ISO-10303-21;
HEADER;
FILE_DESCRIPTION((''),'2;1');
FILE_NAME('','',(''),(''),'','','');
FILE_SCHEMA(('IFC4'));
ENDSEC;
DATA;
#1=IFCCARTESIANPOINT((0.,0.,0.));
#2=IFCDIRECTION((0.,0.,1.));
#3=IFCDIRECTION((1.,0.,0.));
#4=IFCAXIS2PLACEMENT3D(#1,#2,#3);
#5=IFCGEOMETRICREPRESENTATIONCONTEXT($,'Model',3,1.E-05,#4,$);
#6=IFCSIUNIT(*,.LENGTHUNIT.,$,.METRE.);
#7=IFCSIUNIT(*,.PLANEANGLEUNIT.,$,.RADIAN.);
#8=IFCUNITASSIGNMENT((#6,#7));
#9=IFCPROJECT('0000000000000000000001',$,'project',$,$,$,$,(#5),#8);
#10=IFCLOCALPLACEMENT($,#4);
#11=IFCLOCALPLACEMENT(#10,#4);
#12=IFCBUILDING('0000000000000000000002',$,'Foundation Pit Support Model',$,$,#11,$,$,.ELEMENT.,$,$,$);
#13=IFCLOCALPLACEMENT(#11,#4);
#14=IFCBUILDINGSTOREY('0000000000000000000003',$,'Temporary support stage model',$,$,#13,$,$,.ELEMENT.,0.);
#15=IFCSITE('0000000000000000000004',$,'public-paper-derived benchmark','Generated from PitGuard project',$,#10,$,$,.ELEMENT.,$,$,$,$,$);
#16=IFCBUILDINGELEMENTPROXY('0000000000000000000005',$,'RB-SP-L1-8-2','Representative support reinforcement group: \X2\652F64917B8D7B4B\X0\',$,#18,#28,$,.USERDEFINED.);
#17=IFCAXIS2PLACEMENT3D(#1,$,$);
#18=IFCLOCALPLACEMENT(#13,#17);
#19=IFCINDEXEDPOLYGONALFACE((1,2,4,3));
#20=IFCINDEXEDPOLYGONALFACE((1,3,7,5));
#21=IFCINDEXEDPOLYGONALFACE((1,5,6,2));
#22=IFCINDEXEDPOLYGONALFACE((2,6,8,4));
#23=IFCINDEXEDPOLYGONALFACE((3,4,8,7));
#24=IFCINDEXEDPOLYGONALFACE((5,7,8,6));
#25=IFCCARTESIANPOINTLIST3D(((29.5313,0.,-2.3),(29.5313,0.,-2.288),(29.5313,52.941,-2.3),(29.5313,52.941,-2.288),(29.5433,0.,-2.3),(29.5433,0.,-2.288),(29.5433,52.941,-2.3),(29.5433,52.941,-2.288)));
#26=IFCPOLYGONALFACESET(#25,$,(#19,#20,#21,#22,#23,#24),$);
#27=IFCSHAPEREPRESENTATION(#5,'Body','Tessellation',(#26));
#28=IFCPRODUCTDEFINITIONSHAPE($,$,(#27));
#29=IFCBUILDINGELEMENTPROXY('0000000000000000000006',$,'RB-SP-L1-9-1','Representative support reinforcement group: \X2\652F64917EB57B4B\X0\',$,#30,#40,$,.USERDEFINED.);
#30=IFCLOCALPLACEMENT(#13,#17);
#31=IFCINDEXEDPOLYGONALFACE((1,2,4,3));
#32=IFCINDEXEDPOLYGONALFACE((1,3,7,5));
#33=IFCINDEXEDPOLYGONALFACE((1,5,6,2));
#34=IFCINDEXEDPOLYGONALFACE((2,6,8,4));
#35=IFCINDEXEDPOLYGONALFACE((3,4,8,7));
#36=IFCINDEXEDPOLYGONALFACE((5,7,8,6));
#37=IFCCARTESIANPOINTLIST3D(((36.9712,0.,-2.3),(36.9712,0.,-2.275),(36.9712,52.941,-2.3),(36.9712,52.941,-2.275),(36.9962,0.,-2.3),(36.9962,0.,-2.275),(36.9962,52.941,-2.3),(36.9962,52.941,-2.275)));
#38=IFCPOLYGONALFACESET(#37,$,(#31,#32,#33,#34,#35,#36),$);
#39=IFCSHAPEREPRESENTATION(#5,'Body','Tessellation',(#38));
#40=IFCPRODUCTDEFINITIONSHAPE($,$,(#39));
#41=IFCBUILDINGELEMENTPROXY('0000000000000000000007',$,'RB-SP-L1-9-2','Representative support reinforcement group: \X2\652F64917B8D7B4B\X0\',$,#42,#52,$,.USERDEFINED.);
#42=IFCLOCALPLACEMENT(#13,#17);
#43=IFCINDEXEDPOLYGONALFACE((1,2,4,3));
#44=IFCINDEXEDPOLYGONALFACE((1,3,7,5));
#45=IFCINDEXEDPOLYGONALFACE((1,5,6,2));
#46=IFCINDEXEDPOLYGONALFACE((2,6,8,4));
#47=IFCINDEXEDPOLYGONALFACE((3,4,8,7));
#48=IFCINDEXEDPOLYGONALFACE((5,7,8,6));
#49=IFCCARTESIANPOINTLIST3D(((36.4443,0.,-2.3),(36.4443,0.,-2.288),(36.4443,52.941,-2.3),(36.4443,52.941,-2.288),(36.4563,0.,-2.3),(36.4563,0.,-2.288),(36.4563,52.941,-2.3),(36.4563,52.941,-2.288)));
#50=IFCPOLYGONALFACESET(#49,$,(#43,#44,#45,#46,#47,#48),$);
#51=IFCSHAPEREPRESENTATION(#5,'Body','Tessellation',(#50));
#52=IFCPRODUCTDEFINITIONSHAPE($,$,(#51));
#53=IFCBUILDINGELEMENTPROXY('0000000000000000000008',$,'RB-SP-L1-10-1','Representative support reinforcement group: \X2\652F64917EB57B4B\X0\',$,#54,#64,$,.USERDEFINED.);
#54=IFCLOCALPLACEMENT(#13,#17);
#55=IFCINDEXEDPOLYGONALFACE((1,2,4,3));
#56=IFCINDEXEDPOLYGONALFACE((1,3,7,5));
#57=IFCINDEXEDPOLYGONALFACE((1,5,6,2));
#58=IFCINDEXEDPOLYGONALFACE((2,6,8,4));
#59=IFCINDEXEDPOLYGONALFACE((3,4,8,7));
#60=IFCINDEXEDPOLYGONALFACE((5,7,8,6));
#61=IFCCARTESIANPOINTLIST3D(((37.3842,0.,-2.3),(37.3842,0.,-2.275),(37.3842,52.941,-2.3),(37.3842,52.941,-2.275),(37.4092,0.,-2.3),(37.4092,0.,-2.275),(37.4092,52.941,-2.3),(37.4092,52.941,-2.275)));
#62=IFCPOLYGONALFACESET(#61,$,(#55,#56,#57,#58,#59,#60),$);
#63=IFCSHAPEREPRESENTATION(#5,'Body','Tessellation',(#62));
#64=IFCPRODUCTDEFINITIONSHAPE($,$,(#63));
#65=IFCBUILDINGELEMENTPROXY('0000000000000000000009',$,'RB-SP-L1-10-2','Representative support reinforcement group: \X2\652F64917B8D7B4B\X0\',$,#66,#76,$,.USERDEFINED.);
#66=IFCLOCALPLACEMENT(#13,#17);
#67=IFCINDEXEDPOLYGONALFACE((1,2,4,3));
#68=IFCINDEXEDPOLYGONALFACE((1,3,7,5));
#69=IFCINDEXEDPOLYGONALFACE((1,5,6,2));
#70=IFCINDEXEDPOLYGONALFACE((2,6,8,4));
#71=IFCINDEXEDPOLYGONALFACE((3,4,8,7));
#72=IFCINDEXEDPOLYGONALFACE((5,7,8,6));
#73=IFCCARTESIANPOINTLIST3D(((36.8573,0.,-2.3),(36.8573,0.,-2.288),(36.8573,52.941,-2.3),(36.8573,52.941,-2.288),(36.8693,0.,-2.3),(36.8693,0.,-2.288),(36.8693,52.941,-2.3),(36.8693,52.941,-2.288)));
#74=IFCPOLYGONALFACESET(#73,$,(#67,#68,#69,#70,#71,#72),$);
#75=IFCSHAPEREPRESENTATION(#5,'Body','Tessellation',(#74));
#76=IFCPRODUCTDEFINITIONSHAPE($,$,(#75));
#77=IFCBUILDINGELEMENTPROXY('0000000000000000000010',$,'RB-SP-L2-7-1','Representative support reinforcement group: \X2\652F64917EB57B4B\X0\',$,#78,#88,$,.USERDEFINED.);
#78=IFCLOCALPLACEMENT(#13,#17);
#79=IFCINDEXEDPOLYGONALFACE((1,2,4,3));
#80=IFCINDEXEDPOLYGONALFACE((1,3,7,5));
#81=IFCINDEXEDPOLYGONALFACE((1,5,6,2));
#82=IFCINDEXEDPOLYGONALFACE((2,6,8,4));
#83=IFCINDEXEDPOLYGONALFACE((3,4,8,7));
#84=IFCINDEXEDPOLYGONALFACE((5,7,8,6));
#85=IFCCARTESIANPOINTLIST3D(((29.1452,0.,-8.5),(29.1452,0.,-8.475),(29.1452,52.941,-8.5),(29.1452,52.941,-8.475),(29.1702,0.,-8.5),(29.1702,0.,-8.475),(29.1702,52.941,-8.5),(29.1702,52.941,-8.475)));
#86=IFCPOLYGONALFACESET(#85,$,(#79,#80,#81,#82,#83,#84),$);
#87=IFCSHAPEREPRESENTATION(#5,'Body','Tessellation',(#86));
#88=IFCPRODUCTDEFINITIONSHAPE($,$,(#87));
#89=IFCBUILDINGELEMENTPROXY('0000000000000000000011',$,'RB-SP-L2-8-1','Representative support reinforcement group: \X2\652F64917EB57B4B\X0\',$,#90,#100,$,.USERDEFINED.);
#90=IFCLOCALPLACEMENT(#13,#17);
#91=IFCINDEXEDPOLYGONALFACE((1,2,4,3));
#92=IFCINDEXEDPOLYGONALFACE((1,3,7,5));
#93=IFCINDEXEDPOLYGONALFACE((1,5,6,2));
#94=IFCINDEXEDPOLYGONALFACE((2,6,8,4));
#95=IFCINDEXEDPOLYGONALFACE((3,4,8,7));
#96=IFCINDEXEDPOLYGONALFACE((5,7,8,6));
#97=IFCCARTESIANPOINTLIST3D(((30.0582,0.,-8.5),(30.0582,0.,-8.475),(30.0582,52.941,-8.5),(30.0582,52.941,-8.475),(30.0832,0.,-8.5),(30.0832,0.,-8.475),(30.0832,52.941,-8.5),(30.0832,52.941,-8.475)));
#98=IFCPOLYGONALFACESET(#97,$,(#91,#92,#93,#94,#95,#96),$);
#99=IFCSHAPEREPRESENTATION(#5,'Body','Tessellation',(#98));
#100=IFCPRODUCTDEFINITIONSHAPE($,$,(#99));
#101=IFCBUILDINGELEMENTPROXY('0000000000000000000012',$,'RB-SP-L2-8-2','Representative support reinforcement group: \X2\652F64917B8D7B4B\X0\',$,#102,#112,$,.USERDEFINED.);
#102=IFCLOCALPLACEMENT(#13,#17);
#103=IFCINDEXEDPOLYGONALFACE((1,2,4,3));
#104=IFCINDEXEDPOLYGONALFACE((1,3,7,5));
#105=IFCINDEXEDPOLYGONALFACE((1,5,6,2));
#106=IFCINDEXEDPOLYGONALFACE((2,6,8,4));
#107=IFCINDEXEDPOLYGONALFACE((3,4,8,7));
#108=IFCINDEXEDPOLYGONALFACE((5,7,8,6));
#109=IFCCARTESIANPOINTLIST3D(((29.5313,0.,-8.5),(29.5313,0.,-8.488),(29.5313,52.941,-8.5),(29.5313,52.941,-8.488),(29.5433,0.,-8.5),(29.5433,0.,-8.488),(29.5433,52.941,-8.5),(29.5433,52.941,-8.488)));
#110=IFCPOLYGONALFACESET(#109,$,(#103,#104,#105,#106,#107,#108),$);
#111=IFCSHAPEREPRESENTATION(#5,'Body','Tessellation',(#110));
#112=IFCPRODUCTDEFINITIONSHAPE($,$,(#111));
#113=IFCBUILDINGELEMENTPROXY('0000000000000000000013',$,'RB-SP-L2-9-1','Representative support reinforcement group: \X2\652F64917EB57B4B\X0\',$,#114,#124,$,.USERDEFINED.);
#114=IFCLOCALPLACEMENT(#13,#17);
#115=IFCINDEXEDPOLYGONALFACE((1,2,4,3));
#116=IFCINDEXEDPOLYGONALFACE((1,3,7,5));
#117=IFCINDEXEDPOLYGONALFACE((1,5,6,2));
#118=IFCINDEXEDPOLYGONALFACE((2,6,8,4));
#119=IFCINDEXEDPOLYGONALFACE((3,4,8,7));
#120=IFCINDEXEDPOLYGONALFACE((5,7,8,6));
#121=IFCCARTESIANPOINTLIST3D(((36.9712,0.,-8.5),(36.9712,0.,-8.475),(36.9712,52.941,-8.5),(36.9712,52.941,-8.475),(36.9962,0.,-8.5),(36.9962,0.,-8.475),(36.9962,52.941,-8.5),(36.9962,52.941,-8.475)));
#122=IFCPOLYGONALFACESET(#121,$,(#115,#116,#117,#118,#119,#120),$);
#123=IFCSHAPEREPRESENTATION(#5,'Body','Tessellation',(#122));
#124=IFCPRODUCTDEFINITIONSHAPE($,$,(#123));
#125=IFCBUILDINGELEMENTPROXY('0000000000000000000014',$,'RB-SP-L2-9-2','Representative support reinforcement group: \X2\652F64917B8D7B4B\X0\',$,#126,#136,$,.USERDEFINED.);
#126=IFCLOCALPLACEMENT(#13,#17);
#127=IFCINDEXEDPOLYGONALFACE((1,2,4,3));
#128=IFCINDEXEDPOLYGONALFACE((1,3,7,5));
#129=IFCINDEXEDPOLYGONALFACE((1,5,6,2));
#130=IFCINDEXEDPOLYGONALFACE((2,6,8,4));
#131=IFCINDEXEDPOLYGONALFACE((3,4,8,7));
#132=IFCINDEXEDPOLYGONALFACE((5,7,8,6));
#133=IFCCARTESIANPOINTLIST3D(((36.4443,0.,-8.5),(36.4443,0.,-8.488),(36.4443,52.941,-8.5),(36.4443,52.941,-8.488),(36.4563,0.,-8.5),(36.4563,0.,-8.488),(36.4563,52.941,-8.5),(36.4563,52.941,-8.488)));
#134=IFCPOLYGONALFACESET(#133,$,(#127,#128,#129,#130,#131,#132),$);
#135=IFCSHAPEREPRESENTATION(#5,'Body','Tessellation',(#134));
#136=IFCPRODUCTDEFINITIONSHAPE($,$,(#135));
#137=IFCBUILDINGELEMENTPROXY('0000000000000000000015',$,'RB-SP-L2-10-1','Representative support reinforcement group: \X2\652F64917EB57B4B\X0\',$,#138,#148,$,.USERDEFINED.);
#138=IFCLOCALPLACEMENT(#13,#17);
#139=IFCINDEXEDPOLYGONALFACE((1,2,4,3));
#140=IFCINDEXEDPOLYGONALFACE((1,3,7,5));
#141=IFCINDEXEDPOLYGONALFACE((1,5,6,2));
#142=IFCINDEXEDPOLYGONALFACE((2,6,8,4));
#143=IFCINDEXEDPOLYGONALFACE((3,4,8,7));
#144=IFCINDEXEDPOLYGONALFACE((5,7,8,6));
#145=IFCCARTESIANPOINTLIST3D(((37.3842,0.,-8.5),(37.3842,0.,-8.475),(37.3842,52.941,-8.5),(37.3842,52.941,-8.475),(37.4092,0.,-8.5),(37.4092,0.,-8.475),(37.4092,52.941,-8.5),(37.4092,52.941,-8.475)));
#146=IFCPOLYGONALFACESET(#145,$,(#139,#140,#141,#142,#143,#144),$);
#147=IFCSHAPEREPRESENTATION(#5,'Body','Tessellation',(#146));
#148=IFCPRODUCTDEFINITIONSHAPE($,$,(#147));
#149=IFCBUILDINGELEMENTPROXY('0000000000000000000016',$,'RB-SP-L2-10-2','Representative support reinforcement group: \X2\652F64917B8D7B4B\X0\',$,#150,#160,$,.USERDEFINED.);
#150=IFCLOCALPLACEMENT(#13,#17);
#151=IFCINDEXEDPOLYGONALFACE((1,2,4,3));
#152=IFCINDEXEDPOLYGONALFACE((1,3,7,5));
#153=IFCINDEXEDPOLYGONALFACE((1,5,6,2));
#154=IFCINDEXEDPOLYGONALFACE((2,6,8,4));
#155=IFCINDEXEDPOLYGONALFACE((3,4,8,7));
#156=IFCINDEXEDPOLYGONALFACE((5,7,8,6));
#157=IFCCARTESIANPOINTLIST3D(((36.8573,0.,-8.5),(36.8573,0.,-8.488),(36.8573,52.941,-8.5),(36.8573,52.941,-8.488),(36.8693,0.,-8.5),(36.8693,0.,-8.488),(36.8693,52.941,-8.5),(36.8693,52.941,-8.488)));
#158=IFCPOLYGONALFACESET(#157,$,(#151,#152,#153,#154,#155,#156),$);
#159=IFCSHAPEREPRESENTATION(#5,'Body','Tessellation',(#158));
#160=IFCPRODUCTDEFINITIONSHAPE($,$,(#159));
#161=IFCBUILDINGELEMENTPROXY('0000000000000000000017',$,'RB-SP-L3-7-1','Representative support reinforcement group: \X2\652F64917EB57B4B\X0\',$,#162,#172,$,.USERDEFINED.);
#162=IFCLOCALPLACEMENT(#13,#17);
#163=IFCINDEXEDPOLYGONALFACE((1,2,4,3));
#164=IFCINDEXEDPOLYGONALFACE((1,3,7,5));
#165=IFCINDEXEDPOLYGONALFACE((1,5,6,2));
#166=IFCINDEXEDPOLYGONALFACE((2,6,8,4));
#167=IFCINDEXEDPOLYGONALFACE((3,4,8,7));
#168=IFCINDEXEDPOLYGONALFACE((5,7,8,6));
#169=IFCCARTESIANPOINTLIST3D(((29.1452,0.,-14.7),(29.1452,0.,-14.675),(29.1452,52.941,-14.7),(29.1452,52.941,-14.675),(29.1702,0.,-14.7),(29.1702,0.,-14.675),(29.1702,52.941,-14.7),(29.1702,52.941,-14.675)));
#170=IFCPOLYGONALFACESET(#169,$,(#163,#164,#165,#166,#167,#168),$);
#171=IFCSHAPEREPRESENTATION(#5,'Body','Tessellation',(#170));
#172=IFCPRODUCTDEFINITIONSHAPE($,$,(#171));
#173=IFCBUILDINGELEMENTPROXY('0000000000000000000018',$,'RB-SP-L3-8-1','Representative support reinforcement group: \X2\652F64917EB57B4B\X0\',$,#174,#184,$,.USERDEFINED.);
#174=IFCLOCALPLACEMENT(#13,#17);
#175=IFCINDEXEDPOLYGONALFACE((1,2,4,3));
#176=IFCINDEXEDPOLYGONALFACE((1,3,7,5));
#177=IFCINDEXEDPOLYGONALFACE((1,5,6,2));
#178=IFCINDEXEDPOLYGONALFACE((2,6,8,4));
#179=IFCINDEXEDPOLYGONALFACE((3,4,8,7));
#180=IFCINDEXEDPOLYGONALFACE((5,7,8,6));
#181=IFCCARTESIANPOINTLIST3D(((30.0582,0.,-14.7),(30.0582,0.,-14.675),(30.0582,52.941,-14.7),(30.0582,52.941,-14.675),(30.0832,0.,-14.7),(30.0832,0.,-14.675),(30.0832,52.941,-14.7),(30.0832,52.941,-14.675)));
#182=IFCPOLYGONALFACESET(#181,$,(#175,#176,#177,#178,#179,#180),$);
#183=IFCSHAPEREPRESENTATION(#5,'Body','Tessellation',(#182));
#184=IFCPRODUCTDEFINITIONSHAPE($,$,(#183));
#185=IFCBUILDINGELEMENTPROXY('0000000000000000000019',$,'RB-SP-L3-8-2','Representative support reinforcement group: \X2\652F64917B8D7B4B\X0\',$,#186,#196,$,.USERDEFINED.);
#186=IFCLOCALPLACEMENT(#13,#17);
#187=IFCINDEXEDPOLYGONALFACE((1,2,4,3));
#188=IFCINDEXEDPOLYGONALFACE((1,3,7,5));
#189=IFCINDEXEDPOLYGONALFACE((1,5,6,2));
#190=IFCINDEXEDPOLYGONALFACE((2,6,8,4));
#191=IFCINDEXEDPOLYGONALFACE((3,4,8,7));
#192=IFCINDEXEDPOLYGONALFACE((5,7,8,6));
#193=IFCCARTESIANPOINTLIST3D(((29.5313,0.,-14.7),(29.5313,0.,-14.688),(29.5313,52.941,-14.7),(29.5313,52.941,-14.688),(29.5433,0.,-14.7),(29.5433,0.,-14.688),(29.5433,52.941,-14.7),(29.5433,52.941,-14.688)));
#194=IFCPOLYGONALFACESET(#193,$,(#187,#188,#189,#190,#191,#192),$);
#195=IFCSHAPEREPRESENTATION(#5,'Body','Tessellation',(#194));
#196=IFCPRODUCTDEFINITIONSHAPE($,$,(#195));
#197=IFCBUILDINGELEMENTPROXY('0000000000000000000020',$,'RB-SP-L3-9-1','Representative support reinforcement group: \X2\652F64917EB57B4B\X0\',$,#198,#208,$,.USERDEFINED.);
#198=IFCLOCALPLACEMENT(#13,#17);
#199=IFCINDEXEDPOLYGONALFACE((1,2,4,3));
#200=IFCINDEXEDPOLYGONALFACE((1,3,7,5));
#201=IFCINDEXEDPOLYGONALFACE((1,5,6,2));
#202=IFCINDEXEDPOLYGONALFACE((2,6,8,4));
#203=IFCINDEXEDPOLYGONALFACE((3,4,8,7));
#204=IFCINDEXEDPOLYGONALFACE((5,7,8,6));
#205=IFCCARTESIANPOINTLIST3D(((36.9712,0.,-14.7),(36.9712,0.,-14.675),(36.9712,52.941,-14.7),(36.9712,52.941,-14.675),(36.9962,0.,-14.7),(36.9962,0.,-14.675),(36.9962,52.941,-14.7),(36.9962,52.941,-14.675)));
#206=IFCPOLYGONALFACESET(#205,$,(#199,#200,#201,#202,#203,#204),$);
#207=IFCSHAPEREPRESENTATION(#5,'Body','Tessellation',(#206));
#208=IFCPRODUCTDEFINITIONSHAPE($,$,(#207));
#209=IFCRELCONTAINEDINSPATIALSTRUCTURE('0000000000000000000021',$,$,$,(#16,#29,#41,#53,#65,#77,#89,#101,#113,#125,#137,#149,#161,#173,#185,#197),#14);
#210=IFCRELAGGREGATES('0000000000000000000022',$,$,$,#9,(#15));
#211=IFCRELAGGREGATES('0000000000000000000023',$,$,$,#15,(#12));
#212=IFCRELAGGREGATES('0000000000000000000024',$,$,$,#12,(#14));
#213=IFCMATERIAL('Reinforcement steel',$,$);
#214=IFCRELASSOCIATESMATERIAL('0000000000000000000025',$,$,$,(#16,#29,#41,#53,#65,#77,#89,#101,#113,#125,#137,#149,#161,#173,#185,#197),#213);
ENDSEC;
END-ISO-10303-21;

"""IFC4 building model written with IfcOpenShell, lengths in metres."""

from ifc_helpers import new_model, si_unit, frame, origin_with_axes, origin_2d, place, context, project, spatial, rectangle, extrude, material, element, save


model = new_model("IFC4")

# Units and contexts
model_context = context("Model", 3, precision=1e-05, world=origin_with_axes())
ifc_project = project(units=[si_unit("LENGTHUNIT", "METRE"), si_unit("PLANEANGLEUNIT", "RADIAN")], contexts=[model_context])

# Site, building, storey
site_placement = place(None, origin_with_axes())
site = spatial("IfcSite", under=ifc_project, at=site_placement, Name="public-paper-derived benchmark", Description="Generated from PitGuard project", CompositionType="ELEMENT")
building_placement = place(site_placement, origin_with_axes())
building = spatial("IfcBuilding", under=site, at=building_placement, Name="Foundation Pit Support Model", CompositionType="ELEMENT")
storey_placement = place(building_placement, origin_with_axes())
storey = spatial("IfcBuildingStorey", under=building, at=storey_placement, Name="Temporary support stage model", CompositionType="ELEMENT", Elevation=0.0)

# Building element proxies
ifc_material_1 = material(Name="Reinforcement steel")
proxy_1_placement = place(storey_placement, frame((29.5373, 26.4705, -2.3), z_axis=(0.0, 0.0, 1.0), x_axis=(0.0, 1.0, 0.0)))
element("IfcBuildingElementProxy", 1, at=proxy_1_placement, inside=storey, material=ifc_material_1, Name="RB-SP-L1-8-2", Description="Representative support reinforcement group: 支撑箍筋", PredefinedType="USERDEFINED", context=model_context, shape_type="SweptSolid", body=[
    extrude(rectangle(XDim=52.941, YDim=0.012, at=origin_2d()), origin_with_axes(), (0.0, 0.0, 1.0), 0.012),
])
proxy_2_placement = place(storey_placement, frame((36.9837, 26.4705, -2.3), z_axis=(0.0, 0.0, 1.0), x_axis=(0.0, 1.0, 0.0)))
element("IfcBuildingElementProxy", 2, at=proxy_2_placement, inside=storey, material=ifc_material_1, Name="RB-SP-L1-9-1", Description="Representative support reinforcement group: 支撑纵筋", PredefinedType="USERDEFINED", context=model_context, shape_type="SweptSolid", body=[
    extrude(rectangle(XDim=52.941, YDim=0.025, at=origin_2d()), origin_with_axes(), (0.0, 0.0, 1.0), 0.025),
])
proxy_3_placement = place(storey_placement, frame((36.4503, 26.4705, -2.3), z_axis=(0.0, 0.0, 1.0), x_axis=(0.0, 1.0, 0.0)))
element("IfcBuildingElementProxy", 3, at=proxy_3_placement, inside=storey, material=ifc_material_1, Name="RB-SP-L1-9-2", Description="Representative support reinforcement group: 支撑箍筋", PredefinedType="USERDEFINED", context=model_context, shape_type="SweptSolid", body=[
    extrude(rectangle(XDim=52.941, YDim=0.012, at=origin_2d()), origin_with_axes(), (0.0, 0.0, 1.0), 0.012),
])
proxy_4_placement = place(storey_placement, frame((37.3967, 26.4705, -2.3), z_axis=(0.0, 0.0, 1.0), x_axis=(0.0, 1.0, 0.0)))
element("IfcBuildingElementProxy", 4, at=proxy_4_placement, inside=storey, material=ifc_material_1, Name="RB-SP-L1-10-1", Description="Representative support reinforcement group: 支撑纵筋", PredefinedType="USERDEFINED", context=model_context, shape_type="SweptSolid", body=[
    extrude(rectangle(XDim=52.941, YDim=0.025, at=origin_2d()), origin_with_axes(), (0.0, 0.0, 1.0), 0.025),
])
proxy_5_placement = place(storey_placement, frame((36.8633, 26.4705, -2.3), z_axis=(0.0, 0.0, 1.0), x_axis=(0.0, 1.0, 0.0)))
element("IfcBuildingElementProxy", 5, at=proxy_5_placement, inside=storey, material=ifc_material_1, Name="RB-SP-L1-10-2", Description="Representative support reinforcement group: 支撑箍筋", PredefinedType="USERDEFINED", context=model_context, shape_type="SweptSolid", body=[
    extrude(rectangle(XDim=52.941, YDim=0.012, at=origin_2d()), origin_with_axes(), (0.0, 0.0, 1.0), 0.012),
])
for number, where, z_axis, x_axis, name in (
    (6, (29.1577, 26.4705, -8.5), (0.0, 0.0, 1.0), (0.0, 1.0, 0.0), "RB-SP-L2-7-1"),
    (7, (30.0707, 26.4705, -8.5), (0.0, 0.0, 1.0), (0.0, 1.0, 0.0), "RB-SP-L2-8-1"),
):
    element("IfcBuildingElementProxy", number, at=place(storey_placement, frame(where, z_axis=z_axis, x_axis=x_axis)), inside=storey, material=ifc_material_1, Name=name, Description="Representative support reinforcement group: 支撑纵筋", PredefinedType="USERDEFINED", context=model_context, shape_type="SweptSolid", body=[
        extrude(rectangle(XDim=52.941, YDim=0.025, at=origin_2d()), origin_with_axes(), (0.0, 0.0, 1.0), 0.025),
    ])
proxy_6_placement = place(storey_placement, frame((29.5373, 26.4705, -8.5), z_axis=(0.0, 0.0, 1.0), x_axis=(0.0, 1.0, 0.0)))
element("IfcBuildingElementProxy", 8, at=proxy_6_placement, inside=storey, material=ifc_material_1, Name="RB-SP-L2-8-2", Description="Representative support reinforcement group: 支撑箍筋", PredefinedType="USERDEFINED", context=model_context, shape_type="SweptSolid", body=[
    extrude(rectangle(XDim=52.941, YDim=0.012, at=origin_2d()), origin_with_axes(), (0.0, 0.0, 1.0), 0.012),
])
proxy_7_placement = place(storey_placement, frame((36.9837, 26.4705, -8.5), z_axis=(0.0, 0.0, 1.0), x_axis=(0.0, 1.0, 0.0)))
element("IfcBuildingElementProxy", 9, at=proxy_7_placement, inside=storey, material=ifc_material_1, Name="RB-SP-L2-9-1", Description="Representative support reinforcement group: 支撑纵筋", PredefinedType="USERDEFINED", context=model_context, shape_type="SweptSolid", body=[
    extrude(rectangle(XDim=52.941, YDim=0.025, at=origin_2d()), origin_with_axes(), (0.0, 0.0, 1.0), 0.025),
])
proxy_8_placement = place(storey_placement, frame((36.4503, 26.4705, -8.5), z_axis=(0.0, 0.0, 1.0), x_axis=(0.0, 1.0, 0.0)))
element("IfcBuildingElementProxy", 10, at=proxy_8_placement, inside=storey, material=ifc_material_1, Name="RB-SP-L2-9-2", Description="Representative support reinforcement group: 支撑箍筋", PredefinedType="USERDEFINED", context=model_context, shape_type="SweptSolid", body=[
    extrude(rectangle(XDim=52.941, YDim=0.012, at=origin_2d()), origin_with_axes(), (0.0, 0.0, 1.0), 0.012),
])
proxy_9_placement = place(storey_placement, frame((37.3967, 26.4705, -8.5), z_axis=(0.0, 0.0, 1.0), x_axis=(0.0, 1.0, 0.0)))
element("IfcBuildingElementProxy", 11, at=proxy_9_placement, inside=storey, material=ifc_material_1, Name="RB-SP-L2-10-1", Description="Representative support reinforcement group: 支撑纵筋", PredefinedType="USERDEFINED", context=model_context, shape_type="SweptSolid", body=[
    extrude(rectangle(XDim=52.941, YDim=0.025, at=origin_2d()), origin_with_axes(), (0.0, 0.0, 1.0), 0.025),
])
proxy_10_placement = place(storey_placement, frame((36.8633, 26.4705, -8.5), z_axis=(0.0, 0.0, 1.0), x_axis=(0.0, 1.0, 0.0)))
element("IfcBuildingElementProxy", 12, at=proxy_10_placement, inside=storey, material=ifc_material_1, Name="RB-SP-L2-10-2", Description="Representative support reinforcement group: 支撑箍筋", PredefinedType="USERDEFINED", context=model_context, shape_type="SweptSolid", body=[
    extrude(rectangle(XDim=52.941, YDim=0.012, at=origin_2d()), origin_with_axes(), (0.0, 0.0, 1.0), 0.012),
])
for number, where, z_axis, x_axis, name in (
    (13, (29.1577, 26.4705, -14.7), (0.0, 0.0, 1.0), (0.0, 1.0, 0.0), "RB-SP-L3-7-1"),
    (14, (30.0707, 26.4705, -14.7), (0.0, 0.0, 1.0), (0.0, 1.0, 0.0), "RB-SP-L3-8-1"),
):
    element("IfcBuildingElementProxy", number, at=place(storey_placement, frame(where, z_axis=z_axis, x_axis=x_axis)), inside=storey, material=ifc_material_1, Name=name, Description="Representative support reinforcement group: 支撑纵筋", PredefinedType="USERDEFINED", context=model_context, shape_type="SweptSolid", body=[
        extrude(rectangle(XDim=52.941, YDim=0.025, at=origin_2d()), origin_with_axes(), (0.0, 0.0, 1.0), 0.025),
    ])
proxy_11_placement = place(storey_placement, frame((29.5373, 26.4705, -14.7), z_axis=(0.0, 0.0, 1.0), x_axis=(0.0, 1.0, 0.0)))
element("IfcBuildingElementProxy", 15, at=proxy_11_placement, inside=storey, material=ifc_material_1, Name="RB-SP-L3-8-2", Description="Representative support reinforcement group: 支撑箍筋", PredefinedType="USERDEFINED", context=model_context, shape_type="SweptSolid", body=[
    extrude(rectangle(XDim=52.941, YDim=0.012, at=origin_2d()), origin_with_axes(), (0.0, 0.0, 1.0), 0.012),
])
proxy_12_placement = place(storey_placement, frame((36.9837, 26.4705, -14.7), z_axis=(0.0, 0.0, 1.0), x_axis=(0.0, 1.0, 0.0)))
element("IfcBuildingElementProxy", 16, at=proxy_12_placement, inside=storey, material=ifc_material_1, Name="RB-SP-L3-9-1", Description="Representative support reinforcement group: 支撑纵筋", PredefinedType="USERDEFINED", context=model_context, shape_type="SweptSolid", body=[
    extrude(rectangle(XDim=52.941, YDim=0.025, at=origin_2d()), origin_with_axes(), (0.0, 0.0, 1.0), 0.025),
])

save(model, "model.ifc")
